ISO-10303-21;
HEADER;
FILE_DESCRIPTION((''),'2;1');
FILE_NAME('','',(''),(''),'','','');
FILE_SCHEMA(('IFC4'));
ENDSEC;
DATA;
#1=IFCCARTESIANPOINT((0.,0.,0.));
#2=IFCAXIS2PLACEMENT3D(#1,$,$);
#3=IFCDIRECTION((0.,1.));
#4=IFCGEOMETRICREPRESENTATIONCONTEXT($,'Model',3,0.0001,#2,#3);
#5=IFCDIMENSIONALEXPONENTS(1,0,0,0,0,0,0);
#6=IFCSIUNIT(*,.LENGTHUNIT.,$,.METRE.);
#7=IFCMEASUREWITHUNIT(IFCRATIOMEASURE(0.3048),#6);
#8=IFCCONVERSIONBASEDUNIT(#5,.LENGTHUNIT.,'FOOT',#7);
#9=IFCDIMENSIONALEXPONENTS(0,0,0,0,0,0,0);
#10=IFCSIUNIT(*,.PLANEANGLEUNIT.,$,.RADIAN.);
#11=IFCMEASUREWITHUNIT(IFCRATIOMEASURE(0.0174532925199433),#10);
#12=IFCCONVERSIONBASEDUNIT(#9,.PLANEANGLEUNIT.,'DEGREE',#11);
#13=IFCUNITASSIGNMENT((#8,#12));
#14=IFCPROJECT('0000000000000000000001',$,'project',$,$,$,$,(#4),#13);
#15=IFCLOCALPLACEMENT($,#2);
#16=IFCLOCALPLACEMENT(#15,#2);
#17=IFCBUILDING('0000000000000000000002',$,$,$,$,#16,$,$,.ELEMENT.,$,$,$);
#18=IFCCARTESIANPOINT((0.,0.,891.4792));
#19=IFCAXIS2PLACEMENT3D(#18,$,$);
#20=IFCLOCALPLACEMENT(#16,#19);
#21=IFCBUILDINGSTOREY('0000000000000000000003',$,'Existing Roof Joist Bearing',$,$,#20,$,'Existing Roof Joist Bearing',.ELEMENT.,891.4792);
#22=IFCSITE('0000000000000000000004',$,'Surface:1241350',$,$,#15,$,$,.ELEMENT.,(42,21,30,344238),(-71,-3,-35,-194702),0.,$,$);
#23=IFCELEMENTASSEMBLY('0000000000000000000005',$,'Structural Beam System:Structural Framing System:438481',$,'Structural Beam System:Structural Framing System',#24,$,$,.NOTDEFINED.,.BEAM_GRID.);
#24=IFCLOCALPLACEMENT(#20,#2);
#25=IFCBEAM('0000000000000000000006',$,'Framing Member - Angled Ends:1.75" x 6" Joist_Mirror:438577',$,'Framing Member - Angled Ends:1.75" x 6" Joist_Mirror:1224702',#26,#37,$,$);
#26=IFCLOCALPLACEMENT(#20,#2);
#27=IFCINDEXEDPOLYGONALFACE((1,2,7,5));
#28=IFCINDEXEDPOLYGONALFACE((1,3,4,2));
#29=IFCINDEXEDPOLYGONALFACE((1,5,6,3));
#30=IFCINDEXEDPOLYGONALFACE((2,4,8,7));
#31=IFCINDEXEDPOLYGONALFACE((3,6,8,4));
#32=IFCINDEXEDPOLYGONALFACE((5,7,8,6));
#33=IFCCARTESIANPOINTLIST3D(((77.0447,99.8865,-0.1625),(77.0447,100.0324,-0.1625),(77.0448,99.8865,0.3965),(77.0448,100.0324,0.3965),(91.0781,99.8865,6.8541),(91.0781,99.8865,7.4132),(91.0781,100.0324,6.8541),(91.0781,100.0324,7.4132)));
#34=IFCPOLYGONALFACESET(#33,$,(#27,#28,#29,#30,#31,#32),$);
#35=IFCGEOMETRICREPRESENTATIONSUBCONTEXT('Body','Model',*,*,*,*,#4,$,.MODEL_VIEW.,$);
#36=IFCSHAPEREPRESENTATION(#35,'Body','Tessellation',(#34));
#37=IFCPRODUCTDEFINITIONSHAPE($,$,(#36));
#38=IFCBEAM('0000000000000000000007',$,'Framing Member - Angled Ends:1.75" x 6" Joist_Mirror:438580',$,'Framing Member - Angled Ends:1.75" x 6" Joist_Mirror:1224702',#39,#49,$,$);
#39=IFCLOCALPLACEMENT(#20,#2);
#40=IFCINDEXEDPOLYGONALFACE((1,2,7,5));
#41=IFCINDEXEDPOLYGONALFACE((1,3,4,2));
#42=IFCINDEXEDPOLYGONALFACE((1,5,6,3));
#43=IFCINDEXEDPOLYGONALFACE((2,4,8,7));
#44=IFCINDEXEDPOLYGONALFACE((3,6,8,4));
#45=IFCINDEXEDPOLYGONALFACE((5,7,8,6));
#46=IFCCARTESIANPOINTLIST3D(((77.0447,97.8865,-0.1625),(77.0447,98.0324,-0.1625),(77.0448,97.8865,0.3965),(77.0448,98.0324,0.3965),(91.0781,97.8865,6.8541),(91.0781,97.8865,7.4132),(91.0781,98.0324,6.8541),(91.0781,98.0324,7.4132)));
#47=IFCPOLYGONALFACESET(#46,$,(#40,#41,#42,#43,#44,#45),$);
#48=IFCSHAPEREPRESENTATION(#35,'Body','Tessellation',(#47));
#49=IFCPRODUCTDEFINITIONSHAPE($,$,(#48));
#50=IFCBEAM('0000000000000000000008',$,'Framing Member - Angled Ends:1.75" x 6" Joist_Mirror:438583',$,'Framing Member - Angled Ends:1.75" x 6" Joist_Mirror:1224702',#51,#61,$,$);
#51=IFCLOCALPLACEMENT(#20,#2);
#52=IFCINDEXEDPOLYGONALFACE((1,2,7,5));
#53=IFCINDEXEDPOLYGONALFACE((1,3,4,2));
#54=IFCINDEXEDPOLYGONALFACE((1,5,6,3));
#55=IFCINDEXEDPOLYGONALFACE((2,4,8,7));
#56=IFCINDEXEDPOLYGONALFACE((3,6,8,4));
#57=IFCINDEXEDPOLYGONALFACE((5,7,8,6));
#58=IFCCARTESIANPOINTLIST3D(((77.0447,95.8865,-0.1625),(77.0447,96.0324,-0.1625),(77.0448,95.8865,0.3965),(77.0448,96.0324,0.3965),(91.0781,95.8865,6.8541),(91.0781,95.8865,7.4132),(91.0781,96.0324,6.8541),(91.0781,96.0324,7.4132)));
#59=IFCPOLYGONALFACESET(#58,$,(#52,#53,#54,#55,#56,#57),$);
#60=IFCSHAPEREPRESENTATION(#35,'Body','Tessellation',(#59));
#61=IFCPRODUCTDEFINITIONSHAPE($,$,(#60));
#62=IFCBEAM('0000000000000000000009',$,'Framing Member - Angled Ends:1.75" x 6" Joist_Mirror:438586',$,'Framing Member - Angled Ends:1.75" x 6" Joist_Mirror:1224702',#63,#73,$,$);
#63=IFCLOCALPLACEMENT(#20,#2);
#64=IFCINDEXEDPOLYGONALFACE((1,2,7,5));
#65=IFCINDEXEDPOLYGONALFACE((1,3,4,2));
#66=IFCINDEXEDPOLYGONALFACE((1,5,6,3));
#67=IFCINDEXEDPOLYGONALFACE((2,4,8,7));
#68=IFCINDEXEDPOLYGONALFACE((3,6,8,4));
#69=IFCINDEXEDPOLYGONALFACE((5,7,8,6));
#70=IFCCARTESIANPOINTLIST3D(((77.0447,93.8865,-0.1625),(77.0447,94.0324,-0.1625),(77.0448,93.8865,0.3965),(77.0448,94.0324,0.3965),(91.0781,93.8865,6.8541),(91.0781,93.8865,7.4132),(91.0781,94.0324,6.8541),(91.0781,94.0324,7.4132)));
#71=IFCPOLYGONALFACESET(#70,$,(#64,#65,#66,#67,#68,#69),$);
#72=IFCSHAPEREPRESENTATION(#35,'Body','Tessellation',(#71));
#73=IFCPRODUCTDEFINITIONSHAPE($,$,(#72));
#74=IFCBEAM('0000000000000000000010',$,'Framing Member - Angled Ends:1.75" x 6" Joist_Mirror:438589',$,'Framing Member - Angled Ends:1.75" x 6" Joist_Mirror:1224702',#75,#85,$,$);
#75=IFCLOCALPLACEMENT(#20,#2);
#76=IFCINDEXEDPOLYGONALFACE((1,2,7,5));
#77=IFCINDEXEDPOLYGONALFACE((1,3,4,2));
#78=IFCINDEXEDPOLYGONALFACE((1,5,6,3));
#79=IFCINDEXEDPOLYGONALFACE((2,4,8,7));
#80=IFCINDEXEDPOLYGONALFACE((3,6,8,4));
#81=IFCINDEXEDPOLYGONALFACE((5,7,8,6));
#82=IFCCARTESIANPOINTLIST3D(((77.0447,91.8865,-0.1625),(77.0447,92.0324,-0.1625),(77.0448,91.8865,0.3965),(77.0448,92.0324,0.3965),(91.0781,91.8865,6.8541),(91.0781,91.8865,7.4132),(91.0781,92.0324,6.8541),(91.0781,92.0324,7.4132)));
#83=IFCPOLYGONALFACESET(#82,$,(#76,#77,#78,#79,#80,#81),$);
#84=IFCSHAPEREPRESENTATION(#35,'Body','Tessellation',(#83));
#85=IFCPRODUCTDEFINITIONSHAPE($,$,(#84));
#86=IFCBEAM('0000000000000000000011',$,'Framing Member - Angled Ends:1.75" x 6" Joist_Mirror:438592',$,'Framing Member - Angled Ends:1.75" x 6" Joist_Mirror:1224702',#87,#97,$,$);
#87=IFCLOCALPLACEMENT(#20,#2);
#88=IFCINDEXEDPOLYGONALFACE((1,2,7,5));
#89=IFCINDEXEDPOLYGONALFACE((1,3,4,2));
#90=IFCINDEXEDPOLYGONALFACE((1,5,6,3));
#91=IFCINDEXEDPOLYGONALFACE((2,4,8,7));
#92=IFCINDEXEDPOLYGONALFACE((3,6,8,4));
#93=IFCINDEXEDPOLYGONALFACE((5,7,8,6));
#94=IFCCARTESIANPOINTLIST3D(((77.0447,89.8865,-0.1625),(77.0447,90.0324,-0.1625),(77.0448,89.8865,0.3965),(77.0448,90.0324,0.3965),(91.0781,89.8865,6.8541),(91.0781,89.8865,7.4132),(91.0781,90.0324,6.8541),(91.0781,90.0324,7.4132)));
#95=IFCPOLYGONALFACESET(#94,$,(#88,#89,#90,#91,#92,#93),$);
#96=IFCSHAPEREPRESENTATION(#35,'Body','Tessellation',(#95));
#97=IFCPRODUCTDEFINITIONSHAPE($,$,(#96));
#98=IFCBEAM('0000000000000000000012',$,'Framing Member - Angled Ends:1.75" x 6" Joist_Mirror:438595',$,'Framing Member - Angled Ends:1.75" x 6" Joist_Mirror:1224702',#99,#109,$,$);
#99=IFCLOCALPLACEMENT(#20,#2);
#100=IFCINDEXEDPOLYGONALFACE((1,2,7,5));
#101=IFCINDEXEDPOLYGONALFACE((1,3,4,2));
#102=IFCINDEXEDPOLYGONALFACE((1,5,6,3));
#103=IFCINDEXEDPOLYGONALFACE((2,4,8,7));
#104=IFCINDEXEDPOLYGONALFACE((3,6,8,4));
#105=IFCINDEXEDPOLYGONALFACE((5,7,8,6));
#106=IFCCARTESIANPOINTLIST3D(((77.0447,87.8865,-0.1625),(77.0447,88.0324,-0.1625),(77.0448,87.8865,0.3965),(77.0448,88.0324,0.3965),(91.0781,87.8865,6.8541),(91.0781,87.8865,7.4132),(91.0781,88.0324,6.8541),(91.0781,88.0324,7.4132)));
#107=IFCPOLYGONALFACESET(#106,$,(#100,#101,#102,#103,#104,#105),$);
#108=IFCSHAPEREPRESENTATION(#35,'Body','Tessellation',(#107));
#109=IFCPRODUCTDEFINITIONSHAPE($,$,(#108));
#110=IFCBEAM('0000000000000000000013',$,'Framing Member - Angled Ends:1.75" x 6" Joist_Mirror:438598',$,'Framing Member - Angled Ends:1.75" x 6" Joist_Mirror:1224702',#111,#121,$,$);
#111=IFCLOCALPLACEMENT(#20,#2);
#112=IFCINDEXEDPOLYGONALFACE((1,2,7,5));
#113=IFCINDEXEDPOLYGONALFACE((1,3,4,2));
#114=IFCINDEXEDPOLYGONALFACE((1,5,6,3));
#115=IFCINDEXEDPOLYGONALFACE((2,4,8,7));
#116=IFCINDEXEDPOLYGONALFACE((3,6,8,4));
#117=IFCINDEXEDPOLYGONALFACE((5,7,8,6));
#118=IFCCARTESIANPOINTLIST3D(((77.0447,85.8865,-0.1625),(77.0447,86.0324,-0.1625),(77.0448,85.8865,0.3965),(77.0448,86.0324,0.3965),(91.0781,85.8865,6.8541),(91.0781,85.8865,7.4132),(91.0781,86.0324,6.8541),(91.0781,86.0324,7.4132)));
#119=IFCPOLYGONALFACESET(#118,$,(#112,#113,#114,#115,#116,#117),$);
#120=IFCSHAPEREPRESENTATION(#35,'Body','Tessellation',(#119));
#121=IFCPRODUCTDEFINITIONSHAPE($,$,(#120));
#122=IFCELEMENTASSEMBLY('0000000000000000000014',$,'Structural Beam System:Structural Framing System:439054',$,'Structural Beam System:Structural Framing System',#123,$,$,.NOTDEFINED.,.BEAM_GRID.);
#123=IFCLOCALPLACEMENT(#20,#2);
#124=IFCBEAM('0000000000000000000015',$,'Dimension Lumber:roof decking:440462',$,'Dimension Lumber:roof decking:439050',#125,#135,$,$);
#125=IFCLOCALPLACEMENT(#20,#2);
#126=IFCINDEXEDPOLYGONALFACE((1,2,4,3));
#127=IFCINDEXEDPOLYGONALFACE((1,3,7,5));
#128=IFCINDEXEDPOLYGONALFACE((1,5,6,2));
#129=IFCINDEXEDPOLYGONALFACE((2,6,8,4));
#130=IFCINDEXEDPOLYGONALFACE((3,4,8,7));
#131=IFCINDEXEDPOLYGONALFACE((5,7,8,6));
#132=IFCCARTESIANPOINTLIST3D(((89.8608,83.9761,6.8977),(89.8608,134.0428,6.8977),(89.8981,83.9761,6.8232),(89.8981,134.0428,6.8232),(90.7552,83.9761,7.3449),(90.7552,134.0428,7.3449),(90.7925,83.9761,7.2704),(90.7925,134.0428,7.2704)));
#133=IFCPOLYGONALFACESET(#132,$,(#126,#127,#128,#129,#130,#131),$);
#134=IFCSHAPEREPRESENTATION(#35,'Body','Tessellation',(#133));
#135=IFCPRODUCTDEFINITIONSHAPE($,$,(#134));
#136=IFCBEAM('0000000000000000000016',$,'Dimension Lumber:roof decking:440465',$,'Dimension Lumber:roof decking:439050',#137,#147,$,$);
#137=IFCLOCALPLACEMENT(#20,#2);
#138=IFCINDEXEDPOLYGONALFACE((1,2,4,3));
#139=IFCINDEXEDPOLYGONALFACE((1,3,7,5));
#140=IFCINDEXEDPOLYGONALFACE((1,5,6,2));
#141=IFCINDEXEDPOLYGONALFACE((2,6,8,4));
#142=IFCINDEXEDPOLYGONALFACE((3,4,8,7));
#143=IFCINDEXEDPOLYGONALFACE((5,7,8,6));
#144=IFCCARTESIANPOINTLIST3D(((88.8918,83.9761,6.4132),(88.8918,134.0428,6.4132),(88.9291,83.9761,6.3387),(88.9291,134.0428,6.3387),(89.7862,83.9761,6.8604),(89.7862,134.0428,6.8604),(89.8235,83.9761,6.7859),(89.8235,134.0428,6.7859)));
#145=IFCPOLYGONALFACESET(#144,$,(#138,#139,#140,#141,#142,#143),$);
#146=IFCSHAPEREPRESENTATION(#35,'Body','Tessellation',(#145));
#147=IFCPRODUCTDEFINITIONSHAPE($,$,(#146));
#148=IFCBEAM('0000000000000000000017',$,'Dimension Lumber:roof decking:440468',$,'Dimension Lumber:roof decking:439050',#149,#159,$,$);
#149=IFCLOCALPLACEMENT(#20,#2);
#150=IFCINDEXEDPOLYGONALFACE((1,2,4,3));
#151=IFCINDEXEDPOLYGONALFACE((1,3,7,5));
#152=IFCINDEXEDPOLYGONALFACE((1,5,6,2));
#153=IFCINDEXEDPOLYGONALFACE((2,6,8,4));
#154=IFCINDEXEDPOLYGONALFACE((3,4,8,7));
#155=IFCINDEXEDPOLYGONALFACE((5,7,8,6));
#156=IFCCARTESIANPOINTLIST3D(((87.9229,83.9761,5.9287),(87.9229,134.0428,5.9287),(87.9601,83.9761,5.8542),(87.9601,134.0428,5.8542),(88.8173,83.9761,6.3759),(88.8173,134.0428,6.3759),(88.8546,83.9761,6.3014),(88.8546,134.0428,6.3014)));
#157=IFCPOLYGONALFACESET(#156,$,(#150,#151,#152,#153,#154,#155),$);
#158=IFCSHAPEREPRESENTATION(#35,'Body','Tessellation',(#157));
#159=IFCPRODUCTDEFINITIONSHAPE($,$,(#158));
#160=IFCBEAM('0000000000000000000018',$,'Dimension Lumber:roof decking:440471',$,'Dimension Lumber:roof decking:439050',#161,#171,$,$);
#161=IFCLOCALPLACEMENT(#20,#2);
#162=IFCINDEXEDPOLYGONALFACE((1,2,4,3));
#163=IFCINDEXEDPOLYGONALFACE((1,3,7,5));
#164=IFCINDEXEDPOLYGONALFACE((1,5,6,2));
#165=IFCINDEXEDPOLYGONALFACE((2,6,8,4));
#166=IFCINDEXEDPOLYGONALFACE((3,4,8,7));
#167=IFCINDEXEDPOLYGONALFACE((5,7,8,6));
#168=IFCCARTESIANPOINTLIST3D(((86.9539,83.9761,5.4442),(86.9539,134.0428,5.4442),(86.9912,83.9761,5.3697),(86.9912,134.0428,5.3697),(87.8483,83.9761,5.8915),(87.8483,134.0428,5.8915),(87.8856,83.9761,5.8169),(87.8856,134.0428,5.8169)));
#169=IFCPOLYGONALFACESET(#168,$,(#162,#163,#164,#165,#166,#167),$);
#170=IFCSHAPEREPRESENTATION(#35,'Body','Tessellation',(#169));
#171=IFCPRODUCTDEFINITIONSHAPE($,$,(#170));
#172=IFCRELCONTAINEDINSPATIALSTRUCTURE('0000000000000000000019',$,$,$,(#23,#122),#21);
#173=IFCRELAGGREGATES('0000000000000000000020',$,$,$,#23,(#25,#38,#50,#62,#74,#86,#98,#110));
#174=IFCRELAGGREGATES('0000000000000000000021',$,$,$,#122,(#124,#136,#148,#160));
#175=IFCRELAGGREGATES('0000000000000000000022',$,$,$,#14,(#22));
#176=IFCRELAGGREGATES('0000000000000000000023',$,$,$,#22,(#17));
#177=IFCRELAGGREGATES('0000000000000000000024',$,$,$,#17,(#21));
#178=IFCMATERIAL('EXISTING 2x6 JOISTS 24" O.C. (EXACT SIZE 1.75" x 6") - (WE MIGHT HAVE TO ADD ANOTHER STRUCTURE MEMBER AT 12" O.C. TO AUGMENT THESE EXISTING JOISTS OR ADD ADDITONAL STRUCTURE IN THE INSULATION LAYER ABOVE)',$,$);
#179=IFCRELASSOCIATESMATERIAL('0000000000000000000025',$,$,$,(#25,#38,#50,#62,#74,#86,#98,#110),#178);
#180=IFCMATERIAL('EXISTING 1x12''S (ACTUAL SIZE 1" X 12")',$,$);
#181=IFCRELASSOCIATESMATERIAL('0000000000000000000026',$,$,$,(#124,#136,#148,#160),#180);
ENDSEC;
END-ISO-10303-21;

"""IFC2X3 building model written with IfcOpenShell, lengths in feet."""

from ifc_helpers import new_model, entity, si_unit, converted_unit, direction, frame, frame_2d, origin, place, context, subcontext, project, spatial, rectangle, extrude, clip, halfspace, material, element, aggregate, save


model = new_model("IFC2X3")

# Units and contexts
model_context = context("Model", 3, precision=0.0001, world=origin(), true_north=direction((0.0, 1.0)))
body_context = subcontext(model_context, "Body", "Model", "MODEL_VIEW")
ifc_project = project(units=[converted_unit("LENGTHUNIT", "FOOT", entity("IfcRatioMeasure", 0.3048), si_unit("LENGTHUNIT", "METRE"), dimensions=[1, 0, 0, 0, 0, 0, 0]), converted_unit("PLANEANGLEUNIT", "DEGREE", entity("IfcRatioMeasure", 0.0174532925199433), si_unit("PLANEANGLEUNIT", "RADIAN"), dimensions=[0, 0, 0, 0, 0, 0, 0])], contexts=[model_context])

# Site, building, storey
site_placement = place(None, origin())
site = spatial("IfcSite", under=ifc_project, at=site_placement, Name="Surface:1241350", CompositionType="ELEMENT", RefLatitude=(42, 21, 30, 344238), RefLongitude=(-71, -3, -35, -194702), RefElevation=0.0)
building_placement = place(site_placement, origin())
building = spatial("IfcBuilding", under=site, at=building_placement, CompositionType="ELEMENT")
storey_placement = place(building_placement, frame((0.0, 0.0, 891.4792)))
storey = spatial("IfcBuildingStorey", under=building, at=storey_placement, Name="Existing Roof Joist Bearing", LongName="Existing Roof Joist Bearing", CompositionType="ELEMENT", Elevation=891.4792)

# Element assemblies, beams
assembly_1_placement = place(storey_placement, origin())
assembly_1 = element("IfcElementAssembly", 1, at=assembly_1_placement, inside=storey, Name="Structural Beam System:Structural Framing System:438481", ObjectType="Structural Beam System:Structural Framing System", AssemblyPlace="NOTDEFINED", PredefinedType="BEAM_GRID")
ifc_material_1 = material(Name="EXISTING 2x6 JOISTS 24\" O.C. (EXACT SIZE 1.75\" x 6\") - (WE MIGHT HAVE TO ADD ANOTHER STRUCTURE MEMBER AT 12\" O.C. TO AUGMENT THESE EXISTING JOISTS OR ADD ADDITONAL STRUCTURE IN THE INSULATION LAYER ABOVE)")
beam_1_placement = place(assembly_1_placement, frame((91.0781, 99.9594, 7.4132), z_axis=(-0.447214, 0.0, 0.894427), x_axis=(-0.894427, 0.0, -0.447214)))
beam_1 = element("IfcBeam", 2, at=beam_1_placement, material=ifc_material_1, Name="Framing Member - Angled Ends:1.75\" x 6\" Joist_Mirror:438577", ObjectType="Framing Member - Angled Ends:1.75\" x 6\" Joist_Mirror:1224702", context=body_context, shape_type="Clipping", body=[
    clip(clip(extrude(rectangle(XDim=0.5, YDim=0.1458, at=frame_2d((0.0, 0.0), x_axis=(1.0, 0.0))), frame((0.0, 0.0, -0.25), z_axis=(1.0, 0.0, 0.0), x_axis=(0.0, 0.0, -1.0)), (0.0, 0.0, 1.0), 15.9398), halfspace(frame((0.0, -0.0729, 0.0), z_axis=(-0.894389, 0.0, -0.447291), x_axis=(0.0, -1.0, 0.0)), False)), halfspace(frame((15.9398, -0.0729, -0.5), z_axis=(0.894389, 0.0, 0.447291), x_axis=(0.0, 1.0, 0.0)), False)),
])
beam_2_placement = place(assembly_1_placement, frame((91.0781, 97.9594, 7.4132), z_axis=(-0.447214, 0.0, 0.894427), x_axis=(-0.894427, 0.0, -0.447214)))
beam_2 = element("IfcBeam", 3, at=beam_2_placement, material=ifc_material_1, Name="Framing Member - Angled Ends:1.75\" x 6\" Joist_Mirror:438580", ObjectType="Framing Member - Angled Ends:1.75\" x 6\" Joist_Mirror:1224702", context=body_context, shape_type="Clipping", body=[
    clip(clip(extrude(rectangle(XDim=0.5, YDim=0.1458, at=frame_2d((0.0, 0.0), x_axis=(1.0, 0.0))), frame((0.0, 0.0, -0.25), z_axis=(1.0, 0.0, 0.0), x_axis=(0.0, 0.0, -1.0)), (0.0, 0.0, 1.0), 15.9398), halfspace(frame((15.9398, -0.0729, -0.5), z_axis=(0.894389, 0.0, 0.447291), x_axis=(0.0, 1.0, 0.0)), False)), halfspace(frame((0.0, -0.0729, 0.0), z_axis=(-0.894389, 0.0, -0.447291), x_axis=(0.0, -1.0, 0.0)), False)),
])
beam_3_placement = place(assembly_1_placement, frame((91.0781, 95.9594, 7.4132), z_axis=(-0.447214, 0.0, 0.894427), x_axis=(-0.894427, 0.0, -0.447214)))
beam_3 = element("IfcBeam", 4, at=beam_3_placement, material=ifc_material_1, Name="Framing Member - Angled Ends:1.75\" x 6\" Joist_Mirror:438583", ObjectType="Framing Member - Angled Ends:1.75\" x 6\" Joist_Mirror:1224702", context=body_context, shape_type="Clipping", body=[
    clip(clip(extrude(rectangle(XDim=0.5, YDim=0.1458, at=frame_2d((0.0, 0.0), x_axis=(1.0, 0.0))), frame((0.0, 0.0, -0.25), z_axis=(1.0, 0.0, 0.0), x_axis=(0.0, 0.0, -1.0)), (0.0, 0.0, 1.0), 15.9398), halfspace(frame((15.9398, -0.0729, -0.5), z_axis=(0.894389, 0.0, 0.447291), x_axis=(0.0, 1.0, 0.0)), False)), halfspace(frame((0.0, -0.0729, 0.0), z_axis=(-0.894389, 0.0, -0.447291), x_axis=(0.0, -1.0, 0.0)), False)),
])
beam_4_placement = place(assembly_1_placement, frame((91.0781, 93.9594, 7.4132), z_axis=(-0.447214, 0.0, 0.894427), x_axis=(-0.894427, 0.0, -0.447214)))
beam_4 = element("IfcBeam", 5, at=beam_4_placement, material=ifc_material_1, Name="Framing Member - Angled Ends:1.75\" x 6\" Joist_Mirror:438586", ObjectType="Framing Member - Angled Ends:1.75\" x 6\" Joist_Mirror:1224702", context=body_context, shape_type="Clipping", body=[
    clip(clip(extrude(rectangle(XDim=0.5, YDim=0.1458, at=frame_2d((0.0, 0.0), x_axis=(1.0, 0.0))), frame((0.0, 0.0, -0.25), z_axis=(1.0, 0.0, 0.0), x_axis=(0.0, 0.0, -1.0)), (0.0, 0.0, 1.0), 15.9398), halfspace(frame((15.9398, -0.0729, -0.5), z_axis=(0.894389, 0.0, 0.447291), x_axis=(0.0, 1.0, 0.0)), False)), halfspace(frame((0.0, -0.0729, 0.0), z_axis=(-0.894389, 0.0, -0.447291), x_axis=(0.0, -1.0, 0.0)), False)),
])
beam_5_placement = place(assembly_1_placement, frame((91.0781, 91.9594, 7.4132), z_axis=(-0.447214, 0.0, 0.894427), x_axis=(-0.894427, 0.0, -0.447214)))
beam_5 = element("IfcBeam", 6, at=beam_5_placement, material=ifc_material_1, Name="Framing Member - Angled Ends:1.75\" x 6\" Joist_Mirror:438589", ObjectType="Framing Member - Angled Ends:1.75\" x 6\" Joist_Mirror:1224702", context=body_context, shape_type="Clipping", body=[
    clip(clip(extrude(rectangle(XDim=0.5, YDim=0.1458, at=frame_2d((0.0, 0.0), x_axis=(1.0, 0.0))), frame((0.0, 0.0, -0.25), z_axis=(1.0, 0.0, 0.0), x_axis=(0.0, 0.0, -1.0)), (0.0, 0.0, 1.0), 15.9398), halfspace(frame((15.9398, -0.0729, -0.5), z_axis=(0.894389, 0.0, 0.447291), x_axis=(0.0, 1.0, 0.0)), False)), halfspace(frame((0.0, -0.0729, 0.0), z_axis=(-0.894389, 0.0, -0.447291), x_axis=(0.0, -1.0, 0.0)), False)),
])
beam_6_placement = place(assembly_1_placement, frame((91.0781, 89.9594, 7.4132), z_axis=(-0.447214, 0.0, 0.894427), x_axis=(-0.894427, 0.0, -0.447214)))
beam_6 = element("IfcBeam", 7, at=beam_6_placement, material=ifc_material_1, Name="Framing Member - Angled Ends:1.75\" x 6\" Joist_Mirror:438592", ObjectType="Framing Member - Angled Ends:1.75\" x 6\" Joist_Mirror:1224702", context=body_context, shape_type="Clipping", body=[
    clip(clip(extrude(rectangle(XDim=0.5, YDim=0.1458, at=frame_2d((0.0, 0.0), x_axis=(1.0, 0.0))), frame((0.0, 0.0, -0.25), z_axis=(1.0, 0.0, 0.0), x_axis=(0.0, 0.0, -1.0)), (0.0, 0.0, 1.0), 15.9398), halfspace(frame((15.9398, -0.0729, -0.5), z_axis=(0.894389, 0.0, 0.447291), x_axis=(0.0, 1.0, 0.0)), False)), halfspace(frame((0.0, -0.0729, 0.0), z_axis=(-0.894389, 0.0, -0.447291), x_axis=(0.0, -1.0, 0.0)), False)),
])
beam_7_placement = place(assembly_1_placement, frame((91.0781, 87.9594, 7.4132), z_axis=(-0.447214, 0.0, 0.894427), x_axis=(-0.894427, 0.0, -0.447214)))
beam_7 = element("IfcBeam", 8, at=beam_7_placement, material=ifc_material_1, Name="Framing Member - Angled Ends:1.75\" x 6\" Joist_Mirror:438595", ObjectType="Framing Member - Angled Ends:1.75\" x 6\" Joist_Mirror:1224702", context=body_context, shape_type="Clipping", body=[
    clip(clip(extrude(rectangle(XDim=0.5, YDim=0.1458, at=frame_2d((0.0, 0.0), x_axis=(1.0, 0.0))), frame((0.0, 0.0, -0.25), z_axis=(1.0, 0.0, 0.0), x_axis=(0.0, 0.0, -1.0)), (0.0, 0.0, 1.0), 15.9398), halfspace(frame((15.9398, -0.0729, -0.5), z_axis=(0.894389, 0.0, 0.447291), x_axis=(0.0, 1.0, 0.0)), False)), halfspace(frame((0.0, -0.0729, 0.0), z_axis=(-0.894389, 0.0, -0.447291), x_axis=(0.0, -1.0, 0.0)), False)),
])
beam_8_placement = place(assembly_1_placement, frame((91.0781, 85.9594, 7.4132), z_axis=(-0.447214, 0.0, 0.894427), x_axis=(-0.894427, 0.0, -0.447214)))
beam_8 = element("IfcBeam", 9, at=beam_8_placement, material=ifc_material_1, Name="Framing Member - Angled Ends:1.75\" x 6\" Joist_Mirror:438598", ObjectType="Framing Member - Angled Ends:1.75\" x 6\" Joist_Mirror:1224702", context=body_context, shape_type="Clipping", body=[
    clip(clip(extrude(rectangle(XDim=0.5, YDim=0.1458, at=frame_2d((0.0, 0.0), x_axis=(1.0, 0.0))), frame((0.0, 0.0, -0.25), z_axis=(1.0, 0.0, 0.0), x_axis=(0.0, 0.0, -1.0)), (0.0, 0.0, 1.0), 15.9398), halfspace(frame((15.9398, -0.0729, -0.5), z_axis=(0.894389, 0.0, 0.447291), x_axis=(0.0, 1.0, 0.0)), False)), halfspace(frame((0.0, -0.0729, 0.0), z_axis=(-0.894389, 0.0, -0.447291), x_axis=(0.0, -1.0, 0.0)), False)),
])
aggregate(assembly_1, [beam_1, beam_2, beam_3, beam_4, beam_5, beam_6, beam_7, beam_8])
assembly_2_placement = place(storey_placement, origin())
assembly_2 = element("IfcElementAssembly", 10, at=assembly_2_placement, inside=storey, Name="Structural Beam System:Structural Framing System:439054", ObjectType="Structural Beam System:Structural Framing System", AssemblyPlace="NOTDEFINED", PredefinedType="BEAM_GRID")
ifc_material_2 = material(Name="EXISTING 1x12'S (ACTUAL SIZE 1\" X 12\")")
beam_9_placement = place(assembly_2_placement, frame((90.308, 83.9761, 7.1213), z_axis=(0.0, 0.0, 1.0), x_axis=(0.0, 1.0, 0.0)))
beam_9 = element("IfcBeam", 11, at=beam_9_placement, material=ifc_material_2, Name="Dimension Lumber:roof decking:440462", ObjectType="Dimension Lumber:roof decking:439050", context=body_context, shape_type="SweptSolid", body=[
    extrude(rectangle(XDim=0.0833, YDim=1.0, at=frame_2d((0.0, 0.0), x_axis=(0.0, 1.0))), frame((0.0, -0.0186, -0.0373), z_axis=(1.0, 0.0, 0.0), x_axis=(0.0, -0.894427, 0.447214)), (0.0, 0.0, 1.0), 50.0667),
])
beam_10_placement = place(assembly_2_placement, frame((89.339, 83.9761, 6.6368), z_axis=(0.0, 0.0, 1.0), x_axis=(0.0, 1.0, 0.0)))
beam_10 = element("IfcBeam", 12, at=beam_10_placement, material=ifc_material_2, Name="Dimension Lumber:roof decking:440465", ObjectType="Dimension Lumber:roof decking:439050", context=body_context, shape_type="SweptSolid", body=[
    extrude(rectangle(XDim=0.0833, YDim=1.0, at=frame_2d((0.0, 0.0), x_axis=(0.0, 1.0))), frame((0.0, -0.0186, -0.0373), z_axis=(1.0, 0.0, 0.0), x_axis=(0.0, -0.894427, 0.447214)), (0.0, 0.0, 1.0), 50.0667),
])
beam_11_placement = place(assembly_2_placement, frame((88.3701, 83.9761, 6.1523), z_axis=(0.0, 0.0, 1.0), x_axis=(0.0, 1.0, 0.0)))
beam_11 = element("IfcBeam", 13, at=beam_11_placement, material=ifc_material_2, Name="Dimension Lumber:roof decking:440468", ObjectType="Dimension Lumber:roof decking:439050", context=body_context, shape_type="SweptSolid", body=[
    extrude(rectangle(XDim=0.0833, YDim=1.0, at=frame_2d((0.0, 0.0), x_axis=(0.0, 1.0))), frame((0.0, -0.0186, -0.0373), z_axis=(1.0, 0.0, 0.0), x_axis=(0.0, -0.894427, 0.447214)), (0.0, 0.0, 1.0), 50.0667),
])
beam_12_placement = place(assembly_2_placement, frame((87.4011, 83.9761, 5.6679), z_axis=(0.0, 0.0, 1.0), x_axis=(0.0, 1.0, 0.0)))
beam_12 = element("IfcBeam", 14, at=beam_12_placement, material=ifc_material_2, Name="Dimension Lumber:roof decking:440471", ObjectType="Dimension Lumber:roof decking:439050", context=body_context, shape_type="SweptSolid", body=[
    extrude(rectangle(XDim=0.0833, YDim=1.0, at=frame_2d((0.0, 0.0), x_axis=(0.0, 1.0))), frame((0.0, -0.0186, -0.0373), z_axis=(1.0, 0.0, 0.0), x_axis=(0.0, -0.894427, 0.447214)), (0.0, 0.0, 1.0), 50.0667),
])

aggregate(assembly_2, [beam_9, beam_10, beam_11, beam_12])

save(model, "model.ifc")
